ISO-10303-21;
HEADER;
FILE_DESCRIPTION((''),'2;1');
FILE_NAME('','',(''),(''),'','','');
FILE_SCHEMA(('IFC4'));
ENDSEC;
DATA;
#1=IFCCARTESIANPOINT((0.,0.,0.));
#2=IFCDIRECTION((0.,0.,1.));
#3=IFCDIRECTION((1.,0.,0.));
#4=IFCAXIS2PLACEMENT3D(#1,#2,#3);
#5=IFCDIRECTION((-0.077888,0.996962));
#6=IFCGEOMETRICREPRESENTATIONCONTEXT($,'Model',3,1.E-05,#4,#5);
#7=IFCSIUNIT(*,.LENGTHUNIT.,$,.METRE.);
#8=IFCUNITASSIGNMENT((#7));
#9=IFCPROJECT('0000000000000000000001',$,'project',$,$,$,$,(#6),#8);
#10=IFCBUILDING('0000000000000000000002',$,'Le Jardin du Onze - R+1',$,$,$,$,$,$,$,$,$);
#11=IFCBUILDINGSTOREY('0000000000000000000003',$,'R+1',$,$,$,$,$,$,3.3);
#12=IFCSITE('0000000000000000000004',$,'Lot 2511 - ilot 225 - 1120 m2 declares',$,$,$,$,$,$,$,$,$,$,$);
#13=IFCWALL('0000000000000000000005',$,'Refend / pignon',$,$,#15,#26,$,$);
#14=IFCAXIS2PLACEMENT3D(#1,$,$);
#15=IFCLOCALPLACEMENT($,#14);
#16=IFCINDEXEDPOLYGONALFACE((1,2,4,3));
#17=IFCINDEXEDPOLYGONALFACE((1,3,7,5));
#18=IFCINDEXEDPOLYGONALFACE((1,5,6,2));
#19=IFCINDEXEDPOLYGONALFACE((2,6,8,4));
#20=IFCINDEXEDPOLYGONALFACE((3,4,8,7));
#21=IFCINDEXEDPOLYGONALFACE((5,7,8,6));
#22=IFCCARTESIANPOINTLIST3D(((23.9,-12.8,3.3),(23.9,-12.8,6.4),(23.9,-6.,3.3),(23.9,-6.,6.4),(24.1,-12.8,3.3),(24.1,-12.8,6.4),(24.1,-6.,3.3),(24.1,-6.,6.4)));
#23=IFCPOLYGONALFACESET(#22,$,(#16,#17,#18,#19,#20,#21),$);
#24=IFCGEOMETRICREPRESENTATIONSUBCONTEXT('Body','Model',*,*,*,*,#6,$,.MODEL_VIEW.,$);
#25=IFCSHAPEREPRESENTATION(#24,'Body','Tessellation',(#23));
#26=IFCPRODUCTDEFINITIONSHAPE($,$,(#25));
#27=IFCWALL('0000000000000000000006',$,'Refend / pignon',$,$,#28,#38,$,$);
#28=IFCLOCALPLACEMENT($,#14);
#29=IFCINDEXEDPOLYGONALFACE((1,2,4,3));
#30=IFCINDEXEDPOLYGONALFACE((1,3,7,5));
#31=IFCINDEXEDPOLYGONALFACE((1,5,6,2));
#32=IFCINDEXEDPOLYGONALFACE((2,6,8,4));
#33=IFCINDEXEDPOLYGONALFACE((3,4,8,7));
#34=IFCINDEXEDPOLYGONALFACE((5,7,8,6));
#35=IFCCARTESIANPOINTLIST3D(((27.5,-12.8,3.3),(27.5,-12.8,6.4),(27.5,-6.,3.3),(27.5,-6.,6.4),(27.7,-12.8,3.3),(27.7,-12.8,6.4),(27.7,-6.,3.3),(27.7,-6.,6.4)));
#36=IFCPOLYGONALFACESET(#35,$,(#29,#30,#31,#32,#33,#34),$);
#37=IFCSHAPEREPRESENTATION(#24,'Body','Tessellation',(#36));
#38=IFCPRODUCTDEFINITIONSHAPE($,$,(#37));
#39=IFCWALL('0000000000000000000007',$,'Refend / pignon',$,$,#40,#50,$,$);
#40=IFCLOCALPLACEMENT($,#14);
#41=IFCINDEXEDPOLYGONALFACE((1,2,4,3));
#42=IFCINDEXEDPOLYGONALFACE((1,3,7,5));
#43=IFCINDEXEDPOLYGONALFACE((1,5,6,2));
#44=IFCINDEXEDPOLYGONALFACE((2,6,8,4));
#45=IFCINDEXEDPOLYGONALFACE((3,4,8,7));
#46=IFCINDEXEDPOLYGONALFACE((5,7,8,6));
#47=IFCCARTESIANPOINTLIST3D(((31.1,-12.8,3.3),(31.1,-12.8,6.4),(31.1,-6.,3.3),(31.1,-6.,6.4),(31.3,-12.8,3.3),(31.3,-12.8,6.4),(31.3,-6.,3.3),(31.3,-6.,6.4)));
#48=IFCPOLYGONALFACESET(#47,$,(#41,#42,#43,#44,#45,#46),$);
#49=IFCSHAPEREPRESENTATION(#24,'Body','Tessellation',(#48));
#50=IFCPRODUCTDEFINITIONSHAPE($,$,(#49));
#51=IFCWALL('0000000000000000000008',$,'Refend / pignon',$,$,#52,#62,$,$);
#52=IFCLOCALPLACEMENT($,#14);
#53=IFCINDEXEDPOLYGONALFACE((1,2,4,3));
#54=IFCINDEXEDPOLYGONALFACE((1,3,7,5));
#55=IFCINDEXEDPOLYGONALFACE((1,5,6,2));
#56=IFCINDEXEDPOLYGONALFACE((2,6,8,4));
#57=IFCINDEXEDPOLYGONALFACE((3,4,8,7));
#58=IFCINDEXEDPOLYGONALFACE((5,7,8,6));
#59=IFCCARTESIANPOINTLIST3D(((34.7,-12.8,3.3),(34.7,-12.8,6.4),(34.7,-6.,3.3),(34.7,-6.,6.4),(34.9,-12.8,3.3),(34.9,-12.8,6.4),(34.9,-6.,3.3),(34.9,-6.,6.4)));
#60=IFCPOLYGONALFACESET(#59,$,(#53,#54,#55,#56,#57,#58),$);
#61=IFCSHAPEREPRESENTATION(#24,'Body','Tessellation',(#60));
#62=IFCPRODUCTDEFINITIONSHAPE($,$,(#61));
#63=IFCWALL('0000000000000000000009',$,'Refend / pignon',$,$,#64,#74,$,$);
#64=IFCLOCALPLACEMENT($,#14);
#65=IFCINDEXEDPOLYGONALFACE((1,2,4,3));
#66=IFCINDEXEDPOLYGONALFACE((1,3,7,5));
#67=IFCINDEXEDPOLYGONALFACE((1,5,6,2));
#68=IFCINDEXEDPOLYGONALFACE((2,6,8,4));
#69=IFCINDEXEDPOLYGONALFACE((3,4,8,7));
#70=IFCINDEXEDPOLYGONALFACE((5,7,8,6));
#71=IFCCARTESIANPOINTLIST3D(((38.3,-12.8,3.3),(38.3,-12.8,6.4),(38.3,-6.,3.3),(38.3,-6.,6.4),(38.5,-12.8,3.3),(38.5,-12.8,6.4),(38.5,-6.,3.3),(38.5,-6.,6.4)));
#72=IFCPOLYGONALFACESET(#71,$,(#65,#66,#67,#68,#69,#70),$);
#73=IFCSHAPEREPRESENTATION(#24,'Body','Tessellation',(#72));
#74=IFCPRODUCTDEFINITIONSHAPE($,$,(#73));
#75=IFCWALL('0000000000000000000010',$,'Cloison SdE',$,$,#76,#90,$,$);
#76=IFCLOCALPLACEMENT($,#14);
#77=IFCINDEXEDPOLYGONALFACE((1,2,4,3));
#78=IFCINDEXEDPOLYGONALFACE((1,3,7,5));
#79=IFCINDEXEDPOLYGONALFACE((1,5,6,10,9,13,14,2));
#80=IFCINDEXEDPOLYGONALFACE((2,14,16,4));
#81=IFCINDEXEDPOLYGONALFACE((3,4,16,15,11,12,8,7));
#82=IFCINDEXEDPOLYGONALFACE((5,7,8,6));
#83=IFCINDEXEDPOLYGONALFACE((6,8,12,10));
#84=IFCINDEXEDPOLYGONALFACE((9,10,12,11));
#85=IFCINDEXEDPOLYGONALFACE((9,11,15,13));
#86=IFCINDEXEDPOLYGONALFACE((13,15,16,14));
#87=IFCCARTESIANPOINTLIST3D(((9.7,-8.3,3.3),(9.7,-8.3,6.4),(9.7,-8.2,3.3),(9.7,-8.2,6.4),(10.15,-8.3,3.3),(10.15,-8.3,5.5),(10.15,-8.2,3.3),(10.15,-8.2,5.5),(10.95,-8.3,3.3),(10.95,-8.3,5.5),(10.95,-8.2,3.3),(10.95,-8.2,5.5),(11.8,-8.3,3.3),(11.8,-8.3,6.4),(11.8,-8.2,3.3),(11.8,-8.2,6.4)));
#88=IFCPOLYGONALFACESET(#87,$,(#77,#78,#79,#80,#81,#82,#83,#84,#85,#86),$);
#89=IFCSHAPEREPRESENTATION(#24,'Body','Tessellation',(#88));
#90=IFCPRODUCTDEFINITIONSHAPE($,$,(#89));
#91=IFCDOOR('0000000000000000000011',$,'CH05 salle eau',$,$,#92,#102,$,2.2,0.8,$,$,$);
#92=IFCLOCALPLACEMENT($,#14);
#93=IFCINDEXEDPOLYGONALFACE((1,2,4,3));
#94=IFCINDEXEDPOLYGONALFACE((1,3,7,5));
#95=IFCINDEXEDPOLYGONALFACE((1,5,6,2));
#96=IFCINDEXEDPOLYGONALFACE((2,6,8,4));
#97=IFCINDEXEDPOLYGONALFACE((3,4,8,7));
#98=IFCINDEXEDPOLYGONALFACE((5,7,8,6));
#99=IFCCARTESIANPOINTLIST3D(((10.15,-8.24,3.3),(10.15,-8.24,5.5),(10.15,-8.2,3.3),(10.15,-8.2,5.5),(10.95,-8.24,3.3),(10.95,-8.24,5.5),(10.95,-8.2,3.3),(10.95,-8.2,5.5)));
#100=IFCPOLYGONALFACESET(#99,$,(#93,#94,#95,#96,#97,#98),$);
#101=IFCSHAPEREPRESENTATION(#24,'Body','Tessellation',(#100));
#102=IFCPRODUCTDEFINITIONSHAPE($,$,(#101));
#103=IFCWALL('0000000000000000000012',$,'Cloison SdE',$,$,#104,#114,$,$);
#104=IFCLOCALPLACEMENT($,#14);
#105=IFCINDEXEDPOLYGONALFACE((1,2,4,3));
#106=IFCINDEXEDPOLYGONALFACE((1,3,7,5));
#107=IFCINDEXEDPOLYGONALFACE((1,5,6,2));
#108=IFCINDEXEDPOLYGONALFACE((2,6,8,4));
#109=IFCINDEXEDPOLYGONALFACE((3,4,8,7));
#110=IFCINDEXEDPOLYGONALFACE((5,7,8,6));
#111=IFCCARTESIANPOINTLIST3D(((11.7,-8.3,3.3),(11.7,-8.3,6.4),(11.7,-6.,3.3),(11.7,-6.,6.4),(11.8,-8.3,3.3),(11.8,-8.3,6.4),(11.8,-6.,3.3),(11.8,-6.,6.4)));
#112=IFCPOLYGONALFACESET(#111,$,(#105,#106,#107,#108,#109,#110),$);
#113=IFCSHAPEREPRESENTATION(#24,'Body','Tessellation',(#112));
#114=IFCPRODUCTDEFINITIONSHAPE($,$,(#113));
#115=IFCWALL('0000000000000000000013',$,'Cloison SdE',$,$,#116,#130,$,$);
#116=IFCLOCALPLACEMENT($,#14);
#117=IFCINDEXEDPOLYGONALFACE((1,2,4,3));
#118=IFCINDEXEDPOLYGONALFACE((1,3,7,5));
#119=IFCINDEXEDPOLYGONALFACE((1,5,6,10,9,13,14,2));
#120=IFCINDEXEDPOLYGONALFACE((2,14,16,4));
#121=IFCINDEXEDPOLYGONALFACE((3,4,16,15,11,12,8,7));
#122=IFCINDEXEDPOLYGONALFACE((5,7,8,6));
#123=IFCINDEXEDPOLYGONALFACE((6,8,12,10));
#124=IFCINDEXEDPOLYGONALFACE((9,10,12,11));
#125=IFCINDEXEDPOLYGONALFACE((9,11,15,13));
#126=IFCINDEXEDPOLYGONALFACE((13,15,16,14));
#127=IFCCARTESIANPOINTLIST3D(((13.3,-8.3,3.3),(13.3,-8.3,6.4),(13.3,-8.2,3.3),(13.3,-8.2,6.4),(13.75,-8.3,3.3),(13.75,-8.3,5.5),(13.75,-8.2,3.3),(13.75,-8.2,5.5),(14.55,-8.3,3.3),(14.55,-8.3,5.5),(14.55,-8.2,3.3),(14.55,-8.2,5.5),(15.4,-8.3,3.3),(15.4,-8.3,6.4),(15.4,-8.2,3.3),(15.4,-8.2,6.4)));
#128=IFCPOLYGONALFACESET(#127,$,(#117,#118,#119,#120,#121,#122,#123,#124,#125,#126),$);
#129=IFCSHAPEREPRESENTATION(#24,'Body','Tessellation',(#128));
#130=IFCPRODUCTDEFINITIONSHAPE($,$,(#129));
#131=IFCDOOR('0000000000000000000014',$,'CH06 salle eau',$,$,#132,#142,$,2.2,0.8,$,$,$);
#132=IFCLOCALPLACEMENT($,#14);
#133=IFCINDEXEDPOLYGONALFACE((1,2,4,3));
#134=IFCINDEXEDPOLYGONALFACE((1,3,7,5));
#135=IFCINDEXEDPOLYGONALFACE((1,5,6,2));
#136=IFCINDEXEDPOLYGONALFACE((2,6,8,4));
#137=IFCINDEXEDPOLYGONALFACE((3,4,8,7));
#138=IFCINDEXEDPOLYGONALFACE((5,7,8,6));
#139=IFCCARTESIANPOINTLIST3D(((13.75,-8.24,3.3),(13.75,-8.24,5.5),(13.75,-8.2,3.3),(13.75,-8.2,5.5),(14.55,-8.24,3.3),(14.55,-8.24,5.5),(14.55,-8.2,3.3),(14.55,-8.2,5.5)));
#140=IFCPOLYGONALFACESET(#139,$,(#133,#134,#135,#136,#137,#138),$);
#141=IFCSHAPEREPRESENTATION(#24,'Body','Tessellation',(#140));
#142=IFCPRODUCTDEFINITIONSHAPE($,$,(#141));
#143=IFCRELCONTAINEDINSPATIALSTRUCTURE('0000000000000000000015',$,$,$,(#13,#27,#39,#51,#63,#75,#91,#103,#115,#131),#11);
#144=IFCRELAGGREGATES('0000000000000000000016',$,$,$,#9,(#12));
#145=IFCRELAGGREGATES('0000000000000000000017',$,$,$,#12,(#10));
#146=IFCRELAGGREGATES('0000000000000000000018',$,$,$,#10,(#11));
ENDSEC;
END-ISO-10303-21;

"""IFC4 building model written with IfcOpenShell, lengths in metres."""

from ifc_helpers import new_model, si_unit, direction, frame, origin_with_axes, place, context, subcontext, project, spatial, polyline, outline, extrude, element, fill, save


model = new_model("IFC4")

# Units and contexts
model_context = context("Model", 3, precision=1e-05, world=origin_with_axes(), true_north=direction((-0.077888, 0.996962)))
body_context = subcontext(model_context, "Body", "Model", "MODEL_VIEW")
ifc_project = project(units=[si_unit("LENGTHUNIT", "METRE")], contexts=[model_context])

# Site, building, storey
site = spatial("IfcSite", under=ifc_project, Name="Lot 2511 - ilot 225 - 1120 m2 declares")
building = spatial("IfcBuilding", under=site, Name="Le Jardin du Onze - R+1")
storey = spatial("IfcBuildingStorey", under=building, Name="R+1", Elevation=3.3)

# Walls
wall_1_placement = place(None, origin_with_axes())
element("IfcWall", 1, at=wall_1_placement, inside=storey, Name="Refend / pignon", context=body_context, shape_type="SweptSolid", body=[
    extrude(outline(polyline([(24.1, -12.8), (24.1, -6.0), (23.9, -6.0), (23.9, -12.8), (24.1, -12.8)])), frame((0.0, 0.0, 3.3)), (0.0, 0.0, 1.0), 3.1),
])
wall_2_placement = place(None, origin_with_axes())
element("IfcWall", 2, at=wall_2_placement, inside=storey, Name="Refend / pignon", context=body_context, shape_type="SweptSolid", body=[
    extrude(outline(polyline([(27.7, -12.8), (27.7, -6.0), (27.5, -6.0), (27.5, -12.8), (27.7, -12.8)])), frame((0.0, 0.0, 3.3)), (0.0, 0.0, 1.0), 3.1),
])
wall_3_placement = place(None, origin_with_axes())
element("IfcWall", 3, at=wall_3_placement, inside=storey, Name="Refend / pignon", context=body_context, shape_type="SweptSolid", body=[
    extrude(outline(polyline([(31.3, -12.8), (31.3, -6.0), (31.1, -6.0), (31.1, -12.8), (31.3, -12.8)])), frame((0.0, 0.0, 3.3)), (0.0, 0.0, 1.0), 3.1),
])
wall_4_placement = place(None, origin_with_axes())
element("IfcWall", 4, at=wall_4_placement, inside=storey, Name="Refend / pignon", context=body_context, shape_type="SweptSolid", body=[
    extrude(outline(polyline([(34.9, -12.8), (34.9, -6.0), (34.7, -6.0), (34.7, -12.8), (34.9, -12.8)])), frame((0.0, 0.0, 3.3)), (0.0, 0.0, 1.0), 3.1),
])
wall_5_placement = place(None, origin_with_axes())
element("IfcWall", 5, at=wall_5_placement, inside=storey, Name="Refend / pignon", context=body_context, shape_type="SweptSolid", body=[
    extrude(outline(polyline([(38.5, -12.8), (38.5, -6.0), (38.3, -6.0), (38.3, -12.8), (38.5, -12.8)])), frame((0.0, 0.0, 3.3)), (0.0, 0.0, 1.0), 3.1),
])

# Wall, opening, door
wall_6_placement = place(None, origin_with_axes())
wall_6 = element("IfcWall", 6, at=wall_6_placement, inside=storey, Name="Cloison SdE", context=body_context, shape_type="SweptSolid", body=[
    extrude(outline(polyline([(11.8, -8.3), (11.8, -8.2), (9.7, -8.2), (9.7, -8.3), (11.8, -8.3)])), frame((0.0, 0.0, 3.3)), (0.0, 0.0, 1.0), 3.1),
])
opening_1_placement = place(None, origin_with_axes())
opening_1 = element("IfcOpeningElement", 7, at=opening_1_placement, cuts=wall_6, context=body_context, shape_type="SweptSolid", body=[
    extrude(outline(polyline([(10.95, -8.34), (10.95, -8.06), (10.15, -8.06), (10.15, -8.34), (10.95, -8.34)])), frame((0.0, 0.0, 3.3)), (0.0, 0.0, 1.0), 2.2),
])
door_1_placement = place(None, origin_with_axes())
door_1 = element("IfcDoor", 8, at=door_1_placement, inside=storey, Name="CH05 salle eau", OverallHeight=2.2, OverallWidth=0.8, context=body_context, shape_type="SweptSolid", body=[
    extrude(outline(polyline([(10.95, -8.24), (10.95, -8.2), (10.15, -8.2), (10.15, -8.24), (10.95, -8.24)])), frame((0.0, 0.0, 3.3)), (0.0, 0.0, 1.0), 2.2),
])
fill(opening_1, door_1)

# Wall
wall_7_placement = place(None, origin_with_axes())
element("IfcWall", 9, at=wall_7_placement, inside=storey, Name="Cloison SdE", context=body_context, shape_type="SweptSolid", body=[
    extrude(outline(polyline([(11.8, -8.3), (11.8, -6.0), (11.7, -6.0), (11.7, -8.3), (11.8, -8.3)])), frame((0.0, 0.0, 3.3)), (0.0, 0.0, 1.0), 3.1),
])

# Wall, opening, door
wall_8_placement = place(None, origin_with_axes())
wall_8 = element("IfcWall", 10, at=wall_8_placement, inside=storey, Name="Cloison SdE", context=body_context, shape_type="SweptSolid", body=[
    extrude(outline(polyline([(15.4, -8.3), (15.4, -8.2), (13.3, -8.2), (13.3, -8.3), (15.4, -8.3)])), frame((0.0, 0.0, 3.3)), (0.0, 0.0, 1.0), 3.1),
])
opening_2_placement = place(None, origin_with_axes())
opening_2 = element("IfcOpeningElement", 11, at=opening_2_placement, cuts=wall_8, context=body_context, shape_type="SweptSolid", body=[
    extrude(outline(polyline([(14.55, -8.34), (14.55, -8.06), (13.75, -8.06), (13.75, -8.34), (14.55, -8.34)])), frame((0.0, 0.0, 3.3)), (0.0, 0.0, 1.0), 2.2),
])
door_2_placement = place(None, origin_with_axes())
door_2 = element("IfcDoor", 12, at=door_2_placement, inside=storey, Name="CH06 salle eau", OverallHeight=2.2, OverallWidth=0.8, context=body_context, shape_type="SweptSolid", body=[
    extrude(outline(polyline([(14.55, -8.24), (14.55, -8.2), (13.75, -8.2), (13.75, -8.24), (14.55, -8.24)])), frame((0.0, 0.0, 3.3)), (0.0, 0.0, 1.0), 2.2),
])
fill(opening_2, door_2)

save(model, "model.ifc")
